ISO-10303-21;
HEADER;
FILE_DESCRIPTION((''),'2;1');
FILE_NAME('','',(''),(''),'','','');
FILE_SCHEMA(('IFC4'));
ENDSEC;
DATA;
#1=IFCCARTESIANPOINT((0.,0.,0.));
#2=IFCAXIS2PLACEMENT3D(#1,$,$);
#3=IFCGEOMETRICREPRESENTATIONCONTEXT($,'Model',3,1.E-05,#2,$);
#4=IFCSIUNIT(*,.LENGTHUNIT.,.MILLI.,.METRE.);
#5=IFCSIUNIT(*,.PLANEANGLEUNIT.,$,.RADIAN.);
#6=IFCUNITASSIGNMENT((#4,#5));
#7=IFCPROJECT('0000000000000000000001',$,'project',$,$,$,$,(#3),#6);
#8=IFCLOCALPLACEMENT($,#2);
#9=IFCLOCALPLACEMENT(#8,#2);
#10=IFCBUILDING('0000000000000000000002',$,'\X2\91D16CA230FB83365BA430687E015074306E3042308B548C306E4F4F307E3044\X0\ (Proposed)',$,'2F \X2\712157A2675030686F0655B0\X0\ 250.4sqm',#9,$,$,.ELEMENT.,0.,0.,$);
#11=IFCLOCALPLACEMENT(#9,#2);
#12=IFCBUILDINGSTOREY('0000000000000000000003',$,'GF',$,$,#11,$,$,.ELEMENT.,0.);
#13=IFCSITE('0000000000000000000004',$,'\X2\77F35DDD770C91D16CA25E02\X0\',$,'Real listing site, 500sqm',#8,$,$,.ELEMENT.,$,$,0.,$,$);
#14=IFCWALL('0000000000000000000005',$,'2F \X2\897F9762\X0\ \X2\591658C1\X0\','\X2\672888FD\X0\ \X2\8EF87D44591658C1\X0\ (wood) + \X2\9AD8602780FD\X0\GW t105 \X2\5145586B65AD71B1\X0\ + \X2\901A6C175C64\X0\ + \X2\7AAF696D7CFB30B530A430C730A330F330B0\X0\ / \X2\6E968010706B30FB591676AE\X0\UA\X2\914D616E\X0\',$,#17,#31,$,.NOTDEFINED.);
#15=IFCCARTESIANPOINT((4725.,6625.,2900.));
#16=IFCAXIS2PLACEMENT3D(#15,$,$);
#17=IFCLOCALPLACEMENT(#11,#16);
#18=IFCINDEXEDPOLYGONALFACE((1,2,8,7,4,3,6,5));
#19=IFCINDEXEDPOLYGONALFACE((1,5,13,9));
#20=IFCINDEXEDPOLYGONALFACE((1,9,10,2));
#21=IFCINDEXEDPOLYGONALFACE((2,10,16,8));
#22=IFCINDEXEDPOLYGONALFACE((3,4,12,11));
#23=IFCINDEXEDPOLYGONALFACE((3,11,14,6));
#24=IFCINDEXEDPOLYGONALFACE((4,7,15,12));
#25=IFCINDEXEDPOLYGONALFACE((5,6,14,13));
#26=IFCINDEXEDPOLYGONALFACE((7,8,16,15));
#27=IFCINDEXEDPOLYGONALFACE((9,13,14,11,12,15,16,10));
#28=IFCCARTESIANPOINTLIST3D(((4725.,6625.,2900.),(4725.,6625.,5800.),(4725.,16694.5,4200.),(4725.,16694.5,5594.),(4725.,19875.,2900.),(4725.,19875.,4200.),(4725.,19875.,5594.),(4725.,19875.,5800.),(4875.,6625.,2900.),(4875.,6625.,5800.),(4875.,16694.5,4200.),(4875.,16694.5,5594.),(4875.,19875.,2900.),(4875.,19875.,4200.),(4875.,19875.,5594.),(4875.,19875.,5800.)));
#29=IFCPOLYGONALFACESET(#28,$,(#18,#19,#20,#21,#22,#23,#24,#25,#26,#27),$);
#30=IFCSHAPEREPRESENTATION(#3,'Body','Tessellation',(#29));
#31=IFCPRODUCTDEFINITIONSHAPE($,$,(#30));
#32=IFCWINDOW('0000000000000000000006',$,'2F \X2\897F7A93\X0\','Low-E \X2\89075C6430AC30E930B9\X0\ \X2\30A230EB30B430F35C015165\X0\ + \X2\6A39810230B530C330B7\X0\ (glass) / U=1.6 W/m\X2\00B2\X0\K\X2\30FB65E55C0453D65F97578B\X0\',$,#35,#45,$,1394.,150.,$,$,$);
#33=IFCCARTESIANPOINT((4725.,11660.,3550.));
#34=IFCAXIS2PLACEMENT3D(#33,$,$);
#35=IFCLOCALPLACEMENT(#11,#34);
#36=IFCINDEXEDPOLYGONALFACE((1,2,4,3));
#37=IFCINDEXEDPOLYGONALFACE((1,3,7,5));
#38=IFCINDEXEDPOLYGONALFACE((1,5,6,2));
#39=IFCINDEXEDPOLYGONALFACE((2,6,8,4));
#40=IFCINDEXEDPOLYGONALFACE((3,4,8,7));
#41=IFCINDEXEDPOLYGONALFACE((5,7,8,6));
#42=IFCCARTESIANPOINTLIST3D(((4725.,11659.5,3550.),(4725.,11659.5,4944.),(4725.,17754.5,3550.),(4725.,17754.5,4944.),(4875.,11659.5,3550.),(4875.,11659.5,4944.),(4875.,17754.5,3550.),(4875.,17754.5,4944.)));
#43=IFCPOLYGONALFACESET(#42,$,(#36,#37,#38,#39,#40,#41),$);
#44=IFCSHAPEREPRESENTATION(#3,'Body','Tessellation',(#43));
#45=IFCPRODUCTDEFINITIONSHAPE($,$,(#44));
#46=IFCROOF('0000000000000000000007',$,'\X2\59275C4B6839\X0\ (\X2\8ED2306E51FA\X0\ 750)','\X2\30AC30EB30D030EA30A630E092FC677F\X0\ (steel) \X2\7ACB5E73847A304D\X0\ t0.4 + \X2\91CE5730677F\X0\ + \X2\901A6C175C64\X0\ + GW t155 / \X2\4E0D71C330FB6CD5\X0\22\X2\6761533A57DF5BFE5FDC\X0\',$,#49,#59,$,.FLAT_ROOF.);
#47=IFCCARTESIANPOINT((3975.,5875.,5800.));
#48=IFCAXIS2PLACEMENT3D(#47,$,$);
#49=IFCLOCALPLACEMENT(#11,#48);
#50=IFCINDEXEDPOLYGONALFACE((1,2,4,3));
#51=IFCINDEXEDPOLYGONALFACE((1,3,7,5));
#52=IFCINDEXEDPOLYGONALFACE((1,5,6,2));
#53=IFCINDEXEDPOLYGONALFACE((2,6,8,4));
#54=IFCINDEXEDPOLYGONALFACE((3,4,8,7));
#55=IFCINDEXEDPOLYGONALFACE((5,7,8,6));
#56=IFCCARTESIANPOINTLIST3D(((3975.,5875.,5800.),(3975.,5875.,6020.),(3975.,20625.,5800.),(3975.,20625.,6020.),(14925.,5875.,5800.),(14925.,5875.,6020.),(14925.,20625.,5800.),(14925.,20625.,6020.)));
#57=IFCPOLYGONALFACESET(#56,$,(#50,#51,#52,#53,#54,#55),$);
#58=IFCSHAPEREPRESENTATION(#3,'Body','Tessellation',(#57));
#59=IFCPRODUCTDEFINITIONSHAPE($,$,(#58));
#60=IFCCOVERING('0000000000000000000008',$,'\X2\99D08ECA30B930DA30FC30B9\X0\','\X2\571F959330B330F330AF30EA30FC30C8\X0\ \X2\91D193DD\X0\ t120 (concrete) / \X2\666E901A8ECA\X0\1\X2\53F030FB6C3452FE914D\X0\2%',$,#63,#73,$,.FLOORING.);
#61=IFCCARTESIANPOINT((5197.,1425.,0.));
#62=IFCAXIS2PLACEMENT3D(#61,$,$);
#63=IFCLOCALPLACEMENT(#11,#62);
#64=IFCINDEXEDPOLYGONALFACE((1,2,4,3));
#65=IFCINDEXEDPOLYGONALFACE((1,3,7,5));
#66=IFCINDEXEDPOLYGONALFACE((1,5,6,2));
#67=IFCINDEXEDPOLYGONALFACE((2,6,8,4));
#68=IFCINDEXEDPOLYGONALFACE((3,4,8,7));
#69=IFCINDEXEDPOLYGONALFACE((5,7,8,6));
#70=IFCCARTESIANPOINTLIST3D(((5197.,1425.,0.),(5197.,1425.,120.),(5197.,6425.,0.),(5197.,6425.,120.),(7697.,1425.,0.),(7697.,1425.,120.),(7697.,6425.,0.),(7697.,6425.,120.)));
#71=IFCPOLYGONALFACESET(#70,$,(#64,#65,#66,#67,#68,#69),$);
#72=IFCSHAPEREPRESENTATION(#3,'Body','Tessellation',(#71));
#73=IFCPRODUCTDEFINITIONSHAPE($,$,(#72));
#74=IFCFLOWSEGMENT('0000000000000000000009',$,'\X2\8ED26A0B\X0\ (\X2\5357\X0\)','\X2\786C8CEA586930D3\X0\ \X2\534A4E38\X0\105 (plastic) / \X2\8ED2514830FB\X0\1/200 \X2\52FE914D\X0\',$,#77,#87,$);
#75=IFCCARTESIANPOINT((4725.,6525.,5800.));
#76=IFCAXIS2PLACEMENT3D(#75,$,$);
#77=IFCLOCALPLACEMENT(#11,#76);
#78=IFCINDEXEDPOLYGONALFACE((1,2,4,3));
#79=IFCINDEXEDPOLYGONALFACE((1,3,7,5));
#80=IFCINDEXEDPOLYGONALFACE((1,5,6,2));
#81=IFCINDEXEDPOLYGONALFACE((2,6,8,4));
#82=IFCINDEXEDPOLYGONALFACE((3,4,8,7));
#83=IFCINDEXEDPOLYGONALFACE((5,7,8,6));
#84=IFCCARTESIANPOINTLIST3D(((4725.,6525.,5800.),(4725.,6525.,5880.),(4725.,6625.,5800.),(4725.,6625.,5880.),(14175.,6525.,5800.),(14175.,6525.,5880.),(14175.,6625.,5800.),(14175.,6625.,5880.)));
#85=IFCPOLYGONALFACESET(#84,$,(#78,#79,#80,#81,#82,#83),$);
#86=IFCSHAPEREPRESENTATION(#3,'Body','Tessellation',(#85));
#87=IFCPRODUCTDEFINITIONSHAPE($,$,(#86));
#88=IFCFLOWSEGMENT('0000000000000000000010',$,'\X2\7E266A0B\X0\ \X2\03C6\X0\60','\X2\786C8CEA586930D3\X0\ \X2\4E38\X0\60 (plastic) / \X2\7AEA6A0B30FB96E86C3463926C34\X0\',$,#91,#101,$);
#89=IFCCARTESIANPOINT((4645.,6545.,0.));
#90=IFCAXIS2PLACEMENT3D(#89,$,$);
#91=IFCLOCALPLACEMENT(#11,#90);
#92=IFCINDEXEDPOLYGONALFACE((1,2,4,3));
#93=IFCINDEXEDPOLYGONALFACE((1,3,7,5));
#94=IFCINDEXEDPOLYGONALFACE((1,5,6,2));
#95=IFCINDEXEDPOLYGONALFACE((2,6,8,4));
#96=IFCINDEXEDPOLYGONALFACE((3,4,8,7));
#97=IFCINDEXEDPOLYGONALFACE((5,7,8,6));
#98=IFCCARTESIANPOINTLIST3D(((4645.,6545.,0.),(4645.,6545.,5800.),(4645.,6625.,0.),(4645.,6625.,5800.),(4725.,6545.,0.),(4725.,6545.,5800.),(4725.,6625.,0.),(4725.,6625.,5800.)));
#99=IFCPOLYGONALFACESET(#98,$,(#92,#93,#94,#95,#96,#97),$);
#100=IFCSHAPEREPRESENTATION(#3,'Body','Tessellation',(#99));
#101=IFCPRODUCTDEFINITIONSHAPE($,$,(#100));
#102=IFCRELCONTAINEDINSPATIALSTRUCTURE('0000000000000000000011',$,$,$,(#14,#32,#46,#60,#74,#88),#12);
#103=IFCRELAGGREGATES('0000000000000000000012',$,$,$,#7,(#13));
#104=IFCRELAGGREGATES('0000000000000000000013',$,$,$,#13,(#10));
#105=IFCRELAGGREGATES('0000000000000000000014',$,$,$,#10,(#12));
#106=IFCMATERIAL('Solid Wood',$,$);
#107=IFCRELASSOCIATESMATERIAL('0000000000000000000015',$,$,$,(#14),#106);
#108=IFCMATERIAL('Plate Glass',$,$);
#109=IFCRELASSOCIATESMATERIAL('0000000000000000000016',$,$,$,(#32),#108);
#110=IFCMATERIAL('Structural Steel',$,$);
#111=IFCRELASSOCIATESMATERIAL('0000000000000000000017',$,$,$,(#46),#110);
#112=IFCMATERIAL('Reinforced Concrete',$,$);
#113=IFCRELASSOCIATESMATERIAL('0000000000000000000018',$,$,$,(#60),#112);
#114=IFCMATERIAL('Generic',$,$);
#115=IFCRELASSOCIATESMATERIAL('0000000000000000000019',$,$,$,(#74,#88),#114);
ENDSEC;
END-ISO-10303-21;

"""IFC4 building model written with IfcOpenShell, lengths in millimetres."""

from ifc_helpers import new_model, si_unit, frame, frame_2d, origin, place, context, project, spatial, rectangle, extrude, material, element, fill, save


model = new_model("IFC4")

# Units and contexts
model_context = context("Model", 3, precision=1e-05, world=origin())
ifc_project = project(units=[si_unit("LENGTHUNIT", "METRE", prefix="MILLI"), si_unit("PLANEANGLEUNIT", "RADIAN")], contexts=[model_context])

# Site, building, storey
site_placement = place(None, origin())
site = spatial("IfcSite", under=ifc_project, at=site_placement, Name="石川県金沢市", ObjectType="Real listing site, 500sqm", CompositionType="ELEMENT", RefElevation=0.0)
building_placement = place(site_placement, origin())
building = spatial("IfcBuilding", under=site, at=building_placement, Name="金沢・茶室と縁側のある和の住まい (Proposed)", ObjectType="2F 無垢材と漆喰 250.4sqm", CompositionType="ELEMENT", ElevationOfRefHeight=0.0, ElevationOfTerrain=0.0)
storey_placement = place(building_placement, origin())
storey = spatial("IfcBuildingStorey", under=building, at=storey_placement, Name="GF", CompositionType="ELEMENT", Elevation=0.0)

# Shared definitions
ifc_material_1 = material(Name="Solid Wood")

# Shared definitions
ifc_material_2 = material(Name="Reinforced Concrete")

# Shared definitions
ifc_material_3 = material(Name="Plate Glass")

# Wall, opening, window
wall_1_placement = place(storey_placement, frame((4725.0, 6625.0, 2900.0)))
wall_1 = element("IfcWall", 1, at=wall_1_placement, inside=storey, material=ifc_material_1, Name="2F 西面 外壁", Description="木製 軸組外壁 (wood) + 高性能GW t105 充填断熱 + 通気層 + 窯業系サイディング / 準耐火・外皮UA配慮", PredefinedType="NOTDEFINED", context=model_context, shape_type="SweptSolid", body=[
    extrude(rectangle(XDim=150.0, YDim=13250.0, at=frame_2d((75.0, 6625.0))), frame((4725.0, 6625.0, 2900.0)), (0.0, 0.0, 1.0), 2900.0),
])
opening_1_placement = place(storey_placement, frame((4725.0, 11660.0, 3550.0)))
opening_1 = element("IfcOpeningElement", 2, at=opening_1_placement, cuts=wall_1, PredefinedType="NOTDEFINED", context=model_context, shape_type="SweptSolid", body=[
    extrude(rectangle(XDim=150.0, YDim=6095.0, at=frame_2d((75.0, 3047.0))), frame((4725.0, 11660.0, 3550.0)), (0.0, 0.0, 1.0), 1394.0),
])
window_1_placement = place(storey_placement, frame((4725.0, 11660.0, 3550.0)))
window_1 = element("IfcWindow", 3, at=window_1_placement, inside=storey, material=ifc_material_3, Name="2F 西窓", Description="Low-E 複層ガラス アルゴン封入 + 樹脂サッシ (glass) / U=1.6 W/m²K・日射取得型", OverallHeight=1394.0, OverallWidth=150.0, context=model_context, shape_type="SweptSolid", body=[
    extrude(rectangle(XDim=150.0, YDim=6095.0, at=frame_2d((75.0, 3047.0))), frame((4725.0, 11660.0, 3550.0)), (0.0, 0.0, 1.0), 1394.0),
])
fill(opening_1, window_1)

# Roof
ifc_material_4 = material(Name="Structural Steel")
roof_placement = place(storey_placement, frame((3975.0, 5875.0, 5800.0)))
element("IfcRoof", 4, at=roof_placement, inside=storey, material=ifc_material_4, Name="大屋根 (軒の出 750)", Description="ガルバリウム鋼板 (steel) 立平葺き t0.4 + 野地板 + 通気層 + GW t155 / 不燃・法22条区域対応", PredefinedType="FLAT_ROOF", context=model_context, shape_type="SweptSolid", body=[
    extrude(rectangle(XDim=10950.0, YDim=14750.0, at=frame_2d((5475.0, 7375.0))), frame((3975.0, 5875.0, 5800.0)), (0.0, 0.0, 1.0), 220.0),
])

# Covering
covering_placement = place(storey_placement, frame((5197.0, 1425.0, 0.0)))
element("IfcCovering", 5, at=covering_placement, inside=storey, material=ifc_material_2, Name="駐車スペース", Description="土間コンクリート 金鏝 t120 (concrete) / 普通車1台・水勾配2%", PredefinedType="FLOORING", context=model_context, shape_type="SweptSolid", body=[
    extrude(rectangle(XDim=2500.0, YDim=5000.0, at=frame_2d((1250.0, 2500.0))), frame((5197.0, 1425.0, 0.0)), (0.0, 0.0, 1.0), 120.0),
])

# Flow segments
ifc_material_5 = material(Name="Generic")
flow_segment_1_placement = place(storey_placement, frame((4725.0, 6525.0, 5800.0)))
element("IfcFlowSegment", 6, at=flow_segment_1_placement, inside=storey, material=ifc_material_5, Name="軒樋 (南)", Description="硬質塩ビ 半丸105 (plastic) / 軒先・1/200 勾配", context=model_context, shape_type="SweptSolid", body=[
    extrude(rectangle(XDim=9450.0, YDim=100.0, at=frame_2d((4725.0, 50.0))), frame((4725.0, 6525.0, 5800.0)), (0.0, 0.0, 1.0), 80.0),
])
flow_segment_2_placement = place(storey_placement, frame((4645.0, 6545.0, 0.0)))
element("IfcFlowSegment", 7, at=flow_segment_2_placement, inside=storey, material=ifc_material_5, Name="縦樋 φ60", Description="硬質塩ビ 丸60 (plastic) / 竪樋・雨水排水", context=model_context, shape_type="SweptSolid", body=[
    extrude(rectangle(XDim=80.0, YDim=80.0, at=frame_2d((40.0, 40.0))), frame((4645.0, 6545.0, 0.0)), (0.0, 0.0, 1.0), 5800.0),
])

save(model, "model.ifc")
